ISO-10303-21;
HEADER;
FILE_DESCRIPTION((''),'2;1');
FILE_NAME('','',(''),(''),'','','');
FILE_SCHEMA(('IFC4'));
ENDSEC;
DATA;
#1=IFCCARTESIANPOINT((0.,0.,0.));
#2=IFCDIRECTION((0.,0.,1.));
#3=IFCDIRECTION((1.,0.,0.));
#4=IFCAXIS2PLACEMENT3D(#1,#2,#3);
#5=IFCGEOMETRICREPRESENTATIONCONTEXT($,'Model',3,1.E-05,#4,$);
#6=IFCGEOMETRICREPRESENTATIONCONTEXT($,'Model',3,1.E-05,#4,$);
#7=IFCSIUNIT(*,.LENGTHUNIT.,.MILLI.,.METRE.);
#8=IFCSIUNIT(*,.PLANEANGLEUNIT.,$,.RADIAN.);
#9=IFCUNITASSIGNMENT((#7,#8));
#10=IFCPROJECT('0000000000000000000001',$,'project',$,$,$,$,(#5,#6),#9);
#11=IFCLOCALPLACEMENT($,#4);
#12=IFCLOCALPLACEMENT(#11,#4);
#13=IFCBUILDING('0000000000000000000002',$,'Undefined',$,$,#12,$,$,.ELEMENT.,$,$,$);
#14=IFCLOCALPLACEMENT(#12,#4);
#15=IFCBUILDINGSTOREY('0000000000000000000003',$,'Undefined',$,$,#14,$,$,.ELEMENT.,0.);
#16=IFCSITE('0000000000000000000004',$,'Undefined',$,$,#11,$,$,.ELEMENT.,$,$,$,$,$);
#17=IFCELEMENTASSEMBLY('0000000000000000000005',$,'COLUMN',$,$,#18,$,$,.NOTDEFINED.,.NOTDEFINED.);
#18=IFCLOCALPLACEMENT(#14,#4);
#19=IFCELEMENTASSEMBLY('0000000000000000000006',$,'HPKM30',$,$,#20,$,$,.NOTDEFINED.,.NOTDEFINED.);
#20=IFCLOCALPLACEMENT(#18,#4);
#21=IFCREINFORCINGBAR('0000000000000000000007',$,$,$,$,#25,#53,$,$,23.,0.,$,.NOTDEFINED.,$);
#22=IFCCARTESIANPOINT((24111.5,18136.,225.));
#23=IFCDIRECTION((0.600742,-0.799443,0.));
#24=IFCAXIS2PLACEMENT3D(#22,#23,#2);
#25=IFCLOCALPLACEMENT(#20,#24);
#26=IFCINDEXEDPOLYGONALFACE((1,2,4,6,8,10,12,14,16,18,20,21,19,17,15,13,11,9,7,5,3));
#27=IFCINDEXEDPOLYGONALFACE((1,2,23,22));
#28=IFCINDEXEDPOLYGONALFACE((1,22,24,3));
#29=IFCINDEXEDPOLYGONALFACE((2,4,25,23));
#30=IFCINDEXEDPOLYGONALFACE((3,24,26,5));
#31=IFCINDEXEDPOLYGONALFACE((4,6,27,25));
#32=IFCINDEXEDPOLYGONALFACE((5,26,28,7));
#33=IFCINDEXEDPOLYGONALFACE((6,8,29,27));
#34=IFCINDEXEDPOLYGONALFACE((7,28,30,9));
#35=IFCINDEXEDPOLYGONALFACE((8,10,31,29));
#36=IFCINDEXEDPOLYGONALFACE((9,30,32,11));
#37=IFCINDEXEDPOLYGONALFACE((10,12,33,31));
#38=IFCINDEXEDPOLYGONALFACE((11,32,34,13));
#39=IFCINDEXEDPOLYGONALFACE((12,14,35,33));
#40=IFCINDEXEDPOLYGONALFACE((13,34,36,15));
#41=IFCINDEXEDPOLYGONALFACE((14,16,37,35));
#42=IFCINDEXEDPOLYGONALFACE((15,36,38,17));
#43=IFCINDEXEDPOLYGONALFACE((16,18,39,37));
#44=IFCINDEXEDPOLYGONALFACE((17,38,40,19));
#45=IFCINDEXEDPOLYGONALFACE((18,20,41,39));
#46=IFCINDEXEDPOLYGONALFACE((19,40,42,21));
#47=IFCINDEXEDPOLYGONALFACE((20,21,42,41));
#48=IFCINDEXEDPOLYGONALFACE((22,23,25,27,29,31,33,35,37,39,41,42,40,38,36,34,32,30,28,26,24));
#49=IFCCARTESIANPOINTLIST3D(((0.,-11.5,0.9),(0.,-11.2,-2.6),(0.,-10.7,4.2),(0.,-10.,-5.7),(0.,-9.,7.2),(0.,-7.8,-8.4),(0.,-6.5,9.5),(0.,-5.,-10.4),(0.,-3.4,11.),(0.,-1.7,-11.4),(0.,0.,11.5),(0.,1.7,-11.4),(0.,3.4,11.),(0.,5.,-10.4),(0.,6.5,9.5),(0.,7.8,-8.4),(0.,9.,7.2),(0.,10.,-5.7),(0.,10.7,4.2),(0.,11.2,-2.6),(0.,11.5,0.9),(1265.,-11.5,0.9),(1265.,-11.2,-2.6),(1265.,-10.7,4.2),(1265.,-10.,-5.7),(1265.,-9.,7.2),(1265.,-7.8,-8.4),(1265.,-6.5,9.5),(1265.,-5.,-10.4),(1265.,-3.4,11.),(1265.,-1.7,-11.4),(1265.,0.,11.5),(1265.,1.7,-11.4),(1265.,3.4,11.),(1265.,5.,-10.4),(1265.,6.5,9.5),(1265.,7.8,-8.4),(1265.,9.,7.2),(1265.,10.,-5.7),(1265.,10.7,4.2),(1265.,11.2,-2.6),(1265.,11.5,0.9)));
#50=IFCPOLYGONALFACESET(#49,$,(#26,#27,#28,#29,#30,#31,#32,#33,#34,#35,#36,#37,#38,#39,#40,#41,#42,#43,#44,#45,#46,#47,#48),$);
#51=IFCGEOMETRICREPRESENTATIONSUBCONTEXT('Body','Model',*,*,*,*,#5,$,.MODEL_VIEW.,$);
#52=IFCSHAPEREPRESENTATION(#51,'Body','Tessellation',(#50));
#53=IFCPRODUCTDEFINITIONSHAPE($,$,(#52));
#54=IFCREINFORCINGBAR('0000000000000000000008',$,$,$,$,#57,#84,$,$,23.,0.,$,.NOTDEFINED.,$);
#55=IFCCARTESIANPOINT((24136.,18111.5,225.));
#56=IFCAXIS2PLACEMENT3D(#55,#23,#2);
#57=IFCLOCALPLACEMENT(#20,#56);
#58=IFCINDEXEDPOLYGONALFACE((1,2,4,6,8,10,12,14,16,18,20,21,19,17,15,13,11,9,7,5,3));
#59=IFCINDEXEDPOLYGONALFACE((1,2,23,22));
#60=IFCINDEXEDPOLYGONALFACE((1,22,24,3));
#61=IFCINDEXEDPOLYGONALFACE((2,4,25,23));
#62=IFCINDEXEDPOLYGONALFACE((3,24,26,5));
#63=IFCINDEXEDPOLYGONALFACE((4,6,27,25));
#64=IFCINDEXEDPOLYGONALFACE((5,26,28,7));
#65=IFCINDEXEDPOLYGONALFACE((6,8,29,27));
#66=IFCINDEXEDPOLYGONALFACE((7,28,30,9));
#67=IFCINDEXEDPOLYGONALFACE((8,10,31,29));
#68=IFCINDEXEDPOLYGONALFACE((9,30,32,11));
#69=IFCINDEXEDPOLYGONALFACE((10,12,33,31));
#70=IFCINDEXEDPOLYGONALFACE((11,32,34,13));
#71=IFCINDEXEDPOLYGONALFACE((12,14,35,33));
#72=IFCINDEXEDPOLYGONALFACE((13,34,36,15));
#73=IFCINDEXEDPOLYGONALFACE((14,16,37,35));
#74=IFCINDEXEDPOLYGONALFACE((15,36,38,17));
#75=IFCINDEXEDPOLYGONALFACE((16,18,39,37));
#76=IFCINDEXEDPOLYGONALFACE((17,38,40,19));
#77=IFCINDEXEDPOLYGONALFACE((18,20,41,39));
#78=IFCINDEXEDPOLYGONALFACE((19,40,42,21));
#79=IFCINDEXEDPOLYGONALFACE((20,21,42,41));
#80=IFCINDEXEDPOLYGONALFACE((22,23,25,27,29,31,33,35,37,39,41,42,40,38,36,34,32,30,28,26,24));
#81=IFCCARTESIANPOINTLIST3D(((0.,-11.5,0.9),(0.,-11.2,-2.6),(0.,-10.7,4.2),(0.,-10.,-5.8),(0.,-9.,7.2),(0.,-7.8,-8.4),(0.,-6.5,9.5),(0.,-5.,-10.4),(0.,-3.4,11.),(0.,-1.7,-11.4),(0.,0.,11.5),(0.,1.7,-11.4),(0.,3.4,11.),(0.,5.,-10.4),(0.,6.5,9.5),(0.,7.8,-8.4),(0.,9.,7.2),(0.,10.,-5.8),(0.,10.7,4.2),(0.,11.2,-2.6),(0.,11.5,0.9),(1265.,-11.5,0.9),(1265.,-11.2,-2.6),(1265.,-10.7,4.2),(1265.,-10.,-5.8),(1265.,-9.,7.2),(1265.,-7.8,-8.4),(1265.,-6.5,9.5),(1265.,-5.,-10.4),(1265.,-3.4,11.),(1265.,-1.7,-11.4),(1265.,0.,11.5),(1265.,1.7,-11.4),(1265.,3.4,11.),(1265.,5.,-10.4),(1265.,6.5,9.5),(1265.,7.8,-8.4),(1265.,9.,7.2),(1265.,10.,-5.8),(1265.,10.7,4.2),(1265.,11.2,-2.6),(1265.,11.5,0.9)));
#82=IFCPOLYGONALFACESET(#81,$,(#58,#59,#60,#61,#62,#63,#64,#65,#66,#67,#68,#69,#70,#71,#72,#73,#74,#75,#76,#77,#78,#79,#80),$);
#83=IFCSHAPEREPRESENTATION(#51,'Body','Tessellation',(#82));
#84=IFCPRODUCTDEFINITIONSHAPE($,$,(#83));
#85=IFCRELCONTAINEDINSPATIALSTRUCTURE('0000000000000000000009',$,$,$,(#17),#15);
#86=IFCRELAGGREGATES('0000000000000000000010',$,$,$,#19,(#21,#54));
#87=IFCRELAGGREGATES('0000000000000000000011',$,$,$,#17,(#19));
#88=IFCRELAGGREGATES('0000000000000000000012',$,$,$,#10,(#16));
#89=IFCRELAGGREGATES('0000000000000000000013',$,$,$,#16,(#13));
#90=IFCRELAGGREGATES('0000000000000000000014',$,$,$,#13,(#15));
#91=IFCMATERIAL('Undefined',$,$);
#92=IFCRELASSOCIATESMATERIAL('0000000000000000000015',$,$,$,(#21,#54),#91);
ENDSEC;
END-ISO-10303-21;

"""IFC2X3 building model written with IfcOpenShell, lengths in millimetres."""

from ifc_helpers import new_model, entity, si_unit, frame, origin_with_axes, place, context, subcontext, project, spatial, source, transform, mapped, material, element, aggregate, save


model = new_model("IFC2X3")

# Units and contexts
model_context_1 = context("Model", 3, precision=1e-05, world=origin_with_axes())
model_context_2 = context("Model", 3, precision=1e-05, world=origin_with_axes())
body_context = subcontext(model_context_1, "Body", "Model", "MODEL_VIEW")
ifc_project = project(units=[si_unit("LENGTHUNIT", "METRE", prefix="MILLI"), si_unit("PLANEANGLEUNIT", "RADIAN")], contexts=[model_context_1, model_context_2])

# Site, building, storey
site_placement = place(None, origin_with_axes())
site = spatial("IfcSite", under=ifc_project, at=site_placement, Name="Undefined", CompositionType="ELEMENT")
building_placement = place(site_placement, origin_with_axes())
building = spatial("IfcBuilding", under=site, at=building_placement, Name="Undefined", CompositionType="ELEMENT")
storey_placement = place(building_placement, origin_with_axes())
storey = spatial("IfcBuildingStorey", under=building, at=storey_placement, Name="Undefined", CompositionType="ELEMENT", Elevation=0.0)

# Element assemblies
assembly_1_placement = place(storey_placement, origin_with_axes())
assembly_1 = element("IfcElementAssembly", 1, at=assembly_1_placement, inside=storey, Name="COLUMN", AssemblyPlace="NOTDEFINED", PredefinedType="NOTDEFINED")
assembly_2_placement = place(assembly_1_placement, origin_with_axes())
assembly_2 = element("IfcElementAssembly", 2, at=assembly_2_placement, Name="HPKM30", AssemblyPlace="NOTDEFINED", PredefinedType="NOTDEFINED")
ifc_material_1 = material(Name="Undefined")

# Reinforcing bars
shared_shape_1 = source(origin_with_axes(), body_context, "Body", "AdvancedSweptSolid", [
    entity("IfcSweptDiskSolid", entity("IfcTrimmedCurve", entity("IfcLine", entity("IfcCartesianPoint", [0.0, 0.0, 0.0]), entity("IfcVector", entity("IfcDirection", [1.0, 0.0, 0.0]), 1.0)), [entity("IfcParameterValue", 0.0)], [entity("IfcParameterValue", 1265.0)], True, "PARAMETER"), 11.5, None, 0.0, 1265.0),
])
reinforcing_bar_1_placement = place(assembly_2_placement, frame((24111.5, 18136.0, 225.0), z_axis=(0.600742, -0.799443, 0.0), x_axis=(0.0, 0.0, 1.0)))
reinforcing_bar_1 = element("IfcReinforcingBar", 3, at=reinforcing_bar_1_placement, material=ifc_material_1, BarRole="NOTDEFINED", CrossSectionArea=0.0, NominalDiameter=23.0, context=body_context, shape_type="MappedRepresentation", body=[
    mapped(shared_shape_1, transform((0.0, 0.0, 0.0))),
])
shared_shape_2 = source(origin_with_axes(), body_context, "Body", "AdvancedSweptSolid", [
    entity("IfcSweptDiskSolid", entity("IfcTrimmedCurve", entity("IfcLine", entity("IfcCartesianPoint", [0.0, 0.0, 0.0]), entity("IfcVector", entity("IfcDirection", [1.0, 0.0, 0.0]), 1.0)), [entity("IfcParameterValue", 0.0)], [entity("IfcParameterValue", 1265.0)], True, "PARAMETER"), 11.5, None, 0.0, 1265.0),
])
reinforcing_bar_2_placement = place(assembly_2_placement, frame((24136.0, 18111.5, 225.0), z_axis=(0.600742, -0.799443, 0.0), x_axis=(0.0, 0.0, 1.0)))
reinforcing_bar_2 = element("IfcReinforcingBar", 4, at=reinforcing_bar_2_placement, material=ifc_material_1, BarRole="NOTDEFINED", CrossSectionArea=0.0, NominalDiameter=23.0, context=body_context, shape_type="MappedRepresentation", body=[
    mapped(shared_shape_2, transform((0.0, 0.0, 0.0))),
])
aggregate(assembly_2, [reinforcing_bar_1, reinforcing_bar_2])
aggregate(assembly_1, [assembly_2])

save(model, "model.ifc")
